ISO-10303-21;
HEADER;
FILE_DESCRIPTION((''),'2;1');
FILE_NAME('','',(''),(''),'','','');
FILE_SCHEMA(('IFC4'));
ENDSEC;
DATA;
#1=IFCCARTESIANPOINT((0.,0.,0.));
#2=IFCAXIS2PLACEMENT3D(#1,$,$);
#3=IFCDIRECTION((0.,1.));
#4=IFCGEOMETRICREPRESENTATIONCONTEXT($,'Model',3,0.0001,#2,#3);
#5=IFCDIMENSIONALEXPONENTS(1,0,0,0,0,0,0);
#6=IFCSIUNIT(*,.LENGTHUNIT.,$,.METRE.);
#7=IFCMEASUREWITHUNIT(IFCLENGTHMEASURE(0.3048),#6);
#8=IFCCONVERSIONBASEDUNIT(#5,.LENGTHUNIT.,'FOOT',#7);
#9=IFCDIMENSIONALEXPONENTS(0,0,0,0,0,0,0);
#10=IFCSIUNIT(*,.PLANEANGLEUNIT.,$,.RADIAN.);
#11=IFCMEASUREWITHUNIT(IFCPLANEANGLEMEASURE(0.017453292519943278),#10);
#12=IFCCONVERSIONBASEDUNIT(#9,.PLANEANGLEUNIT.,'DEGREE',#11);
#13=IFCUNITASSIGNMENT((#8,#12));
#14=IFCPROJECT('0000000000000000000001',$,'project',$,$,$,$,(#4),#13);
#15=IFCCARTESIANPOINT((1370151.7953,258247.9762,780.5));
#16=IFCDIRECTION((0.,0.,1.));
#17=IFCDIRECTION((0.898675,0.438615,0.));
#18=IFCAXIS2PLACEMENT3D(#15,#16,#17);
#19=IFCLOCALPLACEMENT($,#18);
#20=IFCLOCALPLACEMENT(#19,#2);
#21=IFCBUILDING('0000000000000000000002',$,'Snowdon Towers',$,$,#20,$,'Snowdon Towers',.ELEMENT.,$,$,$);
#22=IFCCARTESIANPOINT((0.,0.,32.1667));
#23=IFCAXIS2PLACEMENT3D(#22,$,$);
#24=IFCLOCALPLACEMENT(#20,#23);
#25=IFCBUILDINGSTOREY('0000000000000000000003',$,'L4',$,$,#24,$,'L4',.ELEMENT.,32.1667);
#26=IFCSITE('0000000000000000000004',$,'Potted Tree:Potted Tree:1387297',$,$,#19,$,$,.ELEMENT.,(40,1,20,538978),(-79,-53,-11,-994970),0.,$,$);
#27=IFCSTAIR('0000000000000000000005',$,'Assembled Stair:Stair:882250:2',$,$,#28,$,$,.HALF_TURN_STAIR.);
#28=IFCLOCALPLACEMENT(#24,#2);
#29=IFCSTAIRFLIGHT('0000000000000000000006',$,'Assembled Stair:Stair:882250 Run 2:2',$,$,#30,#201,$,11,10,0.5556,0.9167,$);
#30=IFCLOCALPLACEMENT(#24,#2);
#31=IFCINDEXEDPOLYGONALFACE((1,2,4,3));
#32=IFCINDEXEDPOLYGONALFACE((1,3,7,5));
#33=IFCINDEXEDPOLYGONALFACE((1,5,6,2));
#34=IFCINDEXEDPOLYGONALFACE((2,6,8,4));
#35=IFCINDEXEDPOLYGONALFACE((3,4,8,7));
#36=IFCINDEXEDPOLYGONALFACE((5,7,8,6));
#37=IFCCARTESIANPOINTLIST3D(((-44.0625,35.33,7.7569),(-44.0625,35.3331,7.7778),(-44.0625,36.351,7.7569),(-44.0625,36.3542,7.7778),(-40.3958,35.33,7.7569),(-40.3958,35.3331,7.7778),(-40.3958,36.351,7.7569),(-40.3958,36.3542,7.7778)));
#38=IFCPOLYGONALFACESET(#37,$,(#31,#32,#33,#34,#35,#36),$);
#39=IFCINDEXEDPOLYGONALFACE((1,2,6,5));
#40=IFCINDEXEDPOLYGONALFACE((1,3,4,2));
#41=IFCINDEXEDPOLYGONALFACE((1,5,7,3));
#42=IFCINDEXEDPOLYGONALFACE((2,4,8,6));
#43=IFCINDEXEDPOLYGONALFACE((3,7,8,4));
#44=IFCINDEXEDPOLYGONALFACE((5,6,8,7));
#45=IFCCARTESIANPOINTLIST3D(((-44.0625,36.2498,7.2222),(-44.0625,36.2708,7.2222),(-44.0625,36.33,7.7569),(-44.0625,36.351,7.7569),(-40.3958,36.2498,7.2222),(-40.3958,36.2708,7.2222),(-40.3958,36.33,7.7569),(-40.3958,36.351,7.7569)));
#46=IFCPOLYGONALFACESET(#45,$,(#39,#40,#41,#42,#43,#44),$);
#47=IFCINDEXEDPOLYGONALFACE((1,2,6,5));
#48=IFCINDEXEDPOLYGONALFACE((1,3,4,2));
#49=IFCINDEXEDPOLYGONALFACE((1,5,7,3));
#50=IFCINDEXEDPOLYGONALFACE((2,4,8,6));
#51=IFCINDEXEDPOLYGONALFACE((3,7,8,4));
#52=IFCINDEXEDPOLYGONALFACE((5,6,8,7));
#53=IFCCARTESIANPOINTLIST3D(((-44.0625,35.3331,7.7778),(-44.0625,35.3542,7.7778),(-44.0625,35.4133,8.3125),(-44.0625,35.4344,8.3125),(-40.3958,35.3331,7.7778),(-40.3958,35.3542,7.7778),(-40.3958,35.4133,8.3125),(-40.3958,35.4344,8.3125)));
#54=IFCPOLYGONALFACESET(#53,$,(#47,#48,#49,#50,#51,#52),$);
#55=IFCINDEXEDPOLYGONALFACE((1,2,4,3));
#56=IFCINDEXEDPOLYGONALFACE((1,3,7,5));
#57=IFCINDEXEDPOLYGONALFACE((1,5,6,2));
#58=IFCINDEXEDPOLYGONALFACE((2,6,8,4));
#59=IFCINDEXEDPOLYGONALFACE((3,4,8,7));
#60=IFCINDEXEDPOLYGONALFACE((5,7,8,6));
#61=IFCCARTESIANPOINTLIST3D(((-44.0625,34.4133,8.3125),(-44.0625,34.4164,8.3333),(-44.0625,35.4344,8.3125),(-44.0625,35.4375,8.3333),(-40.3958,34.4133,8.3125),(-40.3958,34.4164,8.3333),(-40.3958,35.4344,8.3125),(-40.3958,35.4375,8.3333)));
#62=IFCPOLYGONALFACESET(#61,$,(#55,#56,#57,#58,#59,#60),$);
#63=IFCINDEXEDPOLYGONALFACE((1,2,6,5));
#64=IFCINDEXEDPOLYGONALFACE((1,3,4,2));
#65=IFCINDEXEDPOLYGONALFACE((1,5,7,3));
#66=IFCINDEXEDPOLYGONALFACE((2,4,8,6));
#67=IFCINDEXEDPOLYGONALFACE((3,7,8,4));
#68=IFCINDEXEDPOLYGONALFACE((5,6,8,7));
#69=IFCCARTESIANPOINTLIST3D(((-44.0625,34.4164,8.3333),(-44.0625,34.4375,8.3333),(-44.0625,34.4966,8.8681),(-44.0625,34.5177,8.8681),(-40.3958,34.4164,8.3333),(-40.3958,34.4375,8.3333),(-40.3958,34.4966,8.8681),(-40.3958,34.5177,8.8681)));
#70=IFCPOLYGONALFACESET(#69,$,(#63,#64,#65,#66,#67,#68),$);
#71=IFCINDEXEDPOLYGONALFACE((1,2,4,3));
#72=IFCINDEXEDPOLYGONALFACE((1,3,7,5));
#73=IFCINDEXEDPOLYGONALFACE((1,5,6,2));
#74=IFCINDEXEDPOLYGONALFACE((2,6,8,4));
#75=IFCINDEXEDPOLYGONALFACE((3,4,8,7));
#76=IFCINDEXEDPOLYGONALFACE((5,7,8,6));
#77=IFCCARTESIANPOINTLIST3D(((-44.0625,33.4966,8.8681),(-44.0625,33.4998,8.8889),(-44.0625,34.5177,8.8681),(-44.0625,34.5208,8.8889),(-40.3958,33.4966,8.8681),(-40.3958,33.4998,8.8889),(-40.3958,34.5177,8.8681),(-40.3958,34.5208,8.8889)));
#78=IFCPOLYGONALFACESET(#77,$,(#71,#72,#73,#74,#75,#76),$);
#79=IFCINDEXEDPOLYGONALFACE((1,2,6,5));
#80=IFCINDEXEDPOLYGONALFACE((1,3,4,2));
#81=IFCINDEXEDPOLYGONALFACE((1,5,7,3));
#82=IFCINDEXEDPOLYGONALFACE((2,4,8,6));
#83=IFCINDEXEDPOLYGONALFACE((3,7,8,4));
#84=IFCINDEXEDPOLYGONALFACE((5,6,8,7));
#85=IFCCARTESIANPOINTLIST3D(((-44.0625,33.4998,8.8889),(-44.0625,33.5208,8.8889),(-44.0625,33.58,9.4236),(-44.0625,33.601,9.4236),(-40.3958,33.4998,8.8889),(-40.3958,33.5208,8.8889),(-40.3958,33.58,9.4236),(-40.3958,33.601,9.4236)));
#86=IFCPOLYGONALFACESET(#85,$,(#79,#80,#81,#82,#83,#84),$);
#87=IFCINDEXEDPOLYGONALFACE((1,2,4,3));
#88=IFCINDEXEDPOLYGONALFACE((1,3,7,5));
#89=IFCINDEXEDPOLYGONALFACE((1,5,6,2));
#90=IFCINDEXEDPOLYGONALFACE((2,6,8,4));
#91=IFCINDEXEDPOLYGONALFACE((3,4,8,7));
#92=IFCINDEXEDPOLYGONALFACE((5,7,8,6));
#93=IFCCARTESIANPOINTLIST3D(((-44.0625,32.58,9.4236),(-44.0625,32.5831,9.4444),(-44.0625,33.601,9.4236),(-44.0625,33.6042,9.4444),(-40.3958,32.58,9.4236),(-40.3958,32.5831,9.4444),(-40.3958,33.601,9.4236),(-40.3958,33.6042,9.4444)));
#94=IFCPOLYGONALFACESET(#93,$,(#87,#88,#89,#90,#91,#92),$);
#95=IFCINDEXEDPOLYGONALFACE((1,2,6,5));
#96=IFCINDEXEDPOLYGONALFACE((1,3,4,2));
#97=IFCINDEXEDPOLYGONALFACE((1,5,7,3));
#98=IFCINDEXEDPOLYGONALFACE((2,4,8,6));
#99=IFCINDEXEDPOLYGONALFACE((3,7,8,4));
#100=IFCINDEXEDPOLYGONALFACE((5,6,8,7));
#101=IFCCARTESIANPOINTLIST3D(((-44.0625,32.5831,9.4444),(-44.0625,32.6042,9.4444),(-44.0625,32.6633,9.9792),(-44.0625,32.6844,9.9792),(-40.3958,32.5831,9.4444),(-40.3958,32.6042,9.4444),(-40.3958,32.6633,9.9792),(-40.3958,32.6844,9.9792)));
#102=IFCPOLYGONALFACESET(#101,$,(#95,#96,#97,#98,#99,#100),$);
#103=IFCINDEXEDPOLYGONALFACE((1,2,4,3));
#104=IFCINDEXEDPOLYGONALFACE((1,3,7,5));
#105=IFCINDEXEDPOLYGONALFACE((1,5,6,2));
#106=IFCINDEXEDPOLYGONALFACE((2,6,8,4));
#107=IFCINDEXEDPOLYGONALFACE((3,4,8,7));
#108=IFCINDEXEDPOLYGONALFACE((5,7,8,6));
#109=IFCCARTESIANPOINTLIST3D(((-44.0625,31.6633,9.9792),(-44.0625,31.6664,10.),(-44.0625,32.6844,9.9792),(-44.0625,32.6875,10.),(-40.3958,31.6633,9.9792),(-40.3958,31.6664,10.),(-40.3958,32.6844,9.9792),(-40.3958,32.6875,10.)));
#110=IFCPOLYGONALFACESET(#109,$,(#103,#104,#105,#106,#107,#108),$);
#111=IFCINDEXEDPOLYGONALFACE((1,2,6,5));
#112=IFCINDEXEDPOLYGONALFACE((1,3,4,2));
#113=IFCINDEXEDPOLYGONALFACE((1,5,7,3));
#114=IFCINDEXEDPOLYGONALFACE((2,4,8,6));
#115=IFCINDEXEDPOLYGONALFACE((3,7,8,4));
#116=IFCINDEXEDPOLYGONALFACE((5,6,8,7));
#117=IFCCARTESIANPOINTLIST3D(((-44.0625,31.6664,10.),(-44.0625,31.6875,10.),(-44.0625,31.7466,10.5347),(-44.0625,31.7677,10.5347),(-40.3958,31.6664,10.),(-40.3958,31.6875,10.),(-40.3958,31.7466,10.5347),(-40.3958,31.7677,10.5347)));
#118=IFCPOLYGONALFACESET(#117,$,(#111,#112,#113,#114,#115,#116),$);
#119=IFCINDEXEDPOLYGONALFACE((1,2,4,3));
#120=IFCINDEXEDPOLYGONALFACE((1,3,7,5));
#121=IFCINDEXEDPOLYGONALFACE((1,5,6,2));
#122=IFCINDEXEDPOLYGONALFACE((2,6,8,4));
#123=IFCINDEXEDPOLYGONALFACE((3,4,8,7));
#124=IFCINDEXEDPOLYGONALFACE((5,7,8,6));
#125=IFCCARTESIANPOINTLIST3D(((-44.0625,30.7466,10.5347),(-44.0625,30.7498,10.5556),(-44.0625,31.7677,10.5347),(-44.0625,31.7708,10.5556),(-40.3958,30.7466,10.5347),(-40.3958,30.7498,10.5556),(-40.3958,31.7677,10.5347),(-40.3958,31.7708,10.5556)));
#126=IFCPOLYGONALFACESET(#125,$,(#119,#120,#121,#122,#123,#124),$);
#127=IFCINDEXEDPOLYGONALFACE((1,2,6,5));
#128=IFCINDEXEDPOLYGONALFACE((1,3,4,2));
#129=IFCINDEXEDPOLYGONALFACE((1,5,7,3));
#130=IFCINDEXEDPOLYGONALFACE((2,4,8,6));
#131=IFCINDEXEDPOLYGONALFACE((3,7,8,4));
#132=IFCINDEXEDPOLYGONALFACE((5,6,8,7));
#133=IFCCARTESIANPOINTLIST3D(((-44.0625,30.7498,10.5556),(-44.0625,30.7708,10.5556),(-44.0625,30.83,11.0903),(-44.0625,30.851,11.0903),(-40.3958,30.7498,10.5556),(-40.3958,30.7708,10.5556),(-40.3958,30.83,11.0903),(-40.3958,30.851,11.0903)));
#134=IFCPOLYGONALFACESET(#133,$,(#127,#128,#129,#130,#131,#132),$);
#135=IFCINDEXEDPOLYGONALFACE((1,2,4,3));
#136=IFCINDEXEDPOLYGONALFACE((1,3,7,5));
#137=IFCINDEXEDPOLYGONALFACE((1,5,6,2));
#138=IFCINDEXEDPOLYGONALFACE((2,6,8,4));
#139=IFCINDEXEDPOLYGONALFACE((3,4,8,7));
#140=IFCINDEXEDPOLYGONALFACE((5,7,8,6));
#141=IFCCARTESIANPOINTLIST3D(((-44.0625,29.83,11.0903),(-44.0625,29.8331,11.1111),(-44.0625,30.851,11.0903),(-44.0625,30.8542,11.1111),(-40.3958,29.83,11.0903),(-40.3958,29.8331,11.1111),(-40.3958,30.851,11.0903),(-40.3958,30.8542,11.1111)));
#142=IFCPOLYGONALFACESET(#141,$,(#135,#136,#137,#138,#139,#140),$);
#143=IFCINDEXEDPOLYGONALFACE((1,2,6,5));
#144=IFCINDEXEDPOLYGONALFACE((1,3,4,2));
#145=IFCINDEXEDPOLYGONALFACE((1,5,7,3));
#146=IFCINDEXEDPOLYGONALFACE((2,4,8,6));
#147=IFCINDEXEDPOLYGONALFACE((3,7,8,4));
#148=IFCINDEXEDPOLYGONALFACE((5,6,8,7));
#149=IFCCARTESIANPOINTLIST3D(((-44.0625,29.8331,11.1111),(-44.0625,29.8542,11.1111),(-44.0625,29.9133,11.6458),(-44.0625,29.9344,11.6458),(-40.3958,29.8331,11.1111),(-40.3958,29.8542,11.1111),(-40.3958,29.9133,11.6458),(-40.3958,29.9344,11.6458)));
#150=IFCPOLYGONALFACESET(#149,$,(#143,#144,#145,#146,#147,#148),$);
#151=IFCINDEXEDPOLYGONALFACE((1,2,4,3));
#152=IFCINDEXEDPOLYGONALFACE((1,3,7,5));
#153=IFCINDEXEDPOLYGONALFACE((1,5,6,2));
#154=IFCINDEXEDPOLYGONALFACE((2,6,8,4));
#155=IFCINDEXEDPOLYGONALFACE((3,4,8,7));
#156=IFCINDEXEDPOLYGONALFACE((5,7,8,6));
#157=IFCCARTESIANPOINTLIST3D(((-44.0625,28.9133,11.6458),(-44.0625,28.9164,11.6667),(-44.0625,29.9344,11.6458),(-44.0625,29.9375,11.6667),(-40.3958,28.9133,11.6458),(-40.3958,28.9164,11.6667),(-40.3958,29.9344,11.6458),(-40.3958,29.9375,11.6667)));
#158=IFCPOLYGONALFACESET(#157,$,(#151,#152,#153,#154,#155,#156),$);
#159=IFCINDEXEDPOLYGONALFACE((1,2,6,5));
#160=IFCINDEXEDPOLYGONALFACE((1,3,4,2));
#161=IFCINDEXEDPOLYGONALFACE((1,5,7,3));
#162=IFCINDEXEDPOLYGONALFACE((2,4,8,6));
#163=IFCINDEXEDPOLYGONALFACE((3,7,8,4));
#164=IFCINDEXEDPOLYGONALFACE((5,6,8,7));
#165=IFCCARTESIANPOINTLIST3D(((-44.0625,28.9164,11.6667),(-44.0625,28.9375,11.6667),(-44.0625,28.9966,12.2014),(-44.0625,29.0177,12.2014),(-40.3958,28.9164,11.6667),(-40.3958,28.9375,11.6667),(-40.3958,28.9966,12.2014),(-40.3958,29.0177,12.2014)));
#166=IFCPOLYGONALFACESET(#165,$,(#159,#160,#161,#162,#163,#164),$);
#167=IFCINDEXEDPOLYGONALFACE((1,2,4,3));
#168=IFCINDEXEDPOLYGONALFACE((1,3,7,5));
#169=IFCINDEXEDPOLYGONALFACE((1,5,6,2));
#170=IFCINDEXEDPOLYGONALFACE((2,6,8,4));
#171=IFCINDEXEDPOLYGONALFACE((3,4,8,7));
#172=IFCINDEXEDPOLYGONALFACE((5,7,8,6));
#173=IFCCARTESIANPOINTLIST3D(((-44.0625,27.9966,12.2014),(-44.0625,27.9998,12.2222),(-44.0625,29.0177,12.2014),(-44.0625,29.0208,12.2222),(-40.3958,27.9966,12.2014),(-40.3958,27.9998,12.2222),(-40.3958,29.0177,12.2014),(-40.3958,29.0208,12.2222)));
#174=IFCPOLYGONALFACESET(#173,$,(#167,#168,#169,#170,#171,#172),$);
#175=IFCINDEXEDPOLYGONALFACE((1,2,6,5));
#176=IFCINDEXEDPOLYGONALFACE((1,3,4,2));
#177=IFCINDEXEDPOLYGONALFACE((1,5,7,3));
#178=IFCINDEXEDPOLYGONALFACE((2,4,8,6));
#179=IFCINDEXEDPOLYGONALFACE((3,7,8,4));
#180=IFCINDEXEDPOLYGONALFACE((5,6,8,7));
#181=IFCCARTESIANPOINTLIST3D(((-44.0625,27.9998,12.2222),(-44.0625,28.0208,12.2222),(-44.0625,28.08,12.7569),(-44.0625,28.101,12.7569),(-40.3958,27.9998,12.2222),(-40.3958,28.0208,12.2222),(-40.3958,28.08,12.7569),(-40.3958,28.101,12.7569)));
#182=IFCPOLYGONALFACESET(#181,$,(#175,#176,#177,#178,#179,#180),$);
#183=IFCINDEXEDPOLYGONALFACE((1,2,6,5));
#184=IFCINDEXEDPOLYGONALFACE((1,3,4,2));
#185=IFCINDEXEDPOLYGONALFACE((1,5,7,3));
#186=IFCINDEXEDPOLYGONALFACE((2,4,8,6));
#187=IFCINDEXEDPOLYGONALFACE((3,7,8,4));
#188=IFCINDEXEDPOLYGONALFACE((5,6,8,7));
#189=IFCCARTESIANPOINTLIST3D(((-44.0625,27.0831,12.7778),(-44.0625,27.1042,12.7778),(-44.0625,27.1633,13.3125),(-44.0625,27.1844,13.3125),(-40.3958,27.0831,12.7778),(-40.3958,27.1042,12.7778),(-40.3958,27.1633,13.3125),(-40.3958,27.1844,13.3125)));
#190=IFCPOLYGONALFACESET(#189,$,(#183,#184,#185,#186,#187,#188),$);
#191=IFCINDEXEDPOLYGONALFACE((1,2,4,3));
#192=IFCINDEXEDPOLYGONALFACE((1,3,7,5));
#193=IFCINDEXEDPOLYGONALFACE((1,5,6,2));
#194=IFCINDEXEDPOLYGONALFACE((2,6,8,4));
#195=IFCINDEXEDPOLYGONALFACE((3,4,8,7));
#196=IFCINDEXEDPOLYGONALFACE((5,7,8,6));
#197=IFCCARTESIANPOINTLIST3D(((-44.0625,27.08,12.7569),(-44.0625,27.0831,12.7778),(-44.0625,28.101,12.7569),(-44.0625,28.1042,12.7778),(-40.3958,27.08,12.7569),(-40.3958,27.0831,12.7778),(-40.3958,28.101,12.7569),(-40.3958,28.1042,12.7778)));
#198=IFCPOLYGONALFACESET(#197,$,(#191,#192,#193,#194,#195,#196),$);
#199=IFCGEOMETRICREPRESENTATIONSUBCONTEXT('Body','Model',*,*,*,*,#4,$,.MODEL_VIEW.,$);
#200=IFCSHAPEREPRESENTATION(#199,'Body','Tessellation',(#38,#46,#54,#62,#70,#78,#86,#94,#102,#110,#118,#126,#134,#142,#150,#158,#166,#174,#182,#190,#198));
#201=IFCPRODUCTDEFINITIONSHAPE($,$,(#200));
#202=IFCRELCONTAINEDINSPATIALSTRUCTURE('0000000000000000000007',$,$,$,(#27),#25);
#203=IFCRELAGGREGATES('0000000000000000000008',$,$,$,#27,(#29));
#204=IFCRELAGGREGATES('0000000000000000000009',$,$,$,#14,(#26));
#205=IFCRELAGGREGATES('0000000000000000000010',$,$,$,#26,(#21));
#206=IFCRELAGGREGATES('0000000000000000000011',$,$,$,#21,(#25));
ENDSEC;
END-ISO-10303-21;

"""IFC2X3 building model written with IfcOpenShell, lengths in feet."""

from ifc_helpers import new_model, entity, si_unit, converted_unit, direction, frame, origin, place, context, subcontext, project, spatial, polyline, outline, extrude, element, aggregate, save


model = new_model("IFC2X3")

# Units and contexts
model_context = context("Model", 3, precision=0.0001, world=origin(), true_north=direction((0.0, 1.0)))
body_context = subcontext(model_context, "Body", "Model", "MODEL_VIEW")
ifc_project = project(units=[converted_unit("LENGTHUNIT", "FOOT", entity("IfcLengthMeasure", 0.3048), si_unit("LENGTHUNIT", "METRE"), dimensions=[1, 0, 0, 0, 0, 0, 0]), converted_unit("PLANEANGLEUNIT", "DEGREE", entity("IfcPlaneAngleMeasure", 0.017453292519943278), si_unit("PLANEANGLEUNIT", "RADIAN"), dimensions=[0, 0, 0, 0, 0, 0, 0])], contexts=[model_context])

# Site, building, storey
site_placement = place(None, frame((1370151.7953, 258247.9762, 780.5), z_axis=(0.0, 0.0, 1.0), x_axis=(0.898675, 0.438615, 0.0)))
site = spatial("IfcSite", under=ifc_project, at=site_placement, Name="Potted Tree:Potted Tree:1387297", CompositionType="ELEMENT", RefLatitude=(40, 1, 20, 538978), RefLongitude=(-79, -53, -11, -994970), RefElevation=0.0)
building_placement = place(site_placement, origin())
building = spatial("IfcBuilding", under=site, at=building_placement, Name="Snowdon Towers", LongName="Snowdon Towers", CompositionType="ELEMENT")
storey_placement = place(building_placement, frame((0.0, 0.0, 32.1667)))
storey = spatial("IfcBuildingStorey", under=building, at=storey_placement, Name="L4", LongName="L4", CompositionType="ELEMENT", Elevation=32.1667)

# Stair, stair flight
stair_1_placement = place(storey_placement, origin())
stair_1 = element("IfcStair", 1, at=stair_1_placement, inside=storey, Name="Assembled Stair:Stair:882250:2", ShapeType="HALF_TURN_STAIR")
stair_flight_placement = place(stair_1_placement, origin())
stair_flight = element("IfcStairFlight", 2, at=stair_flight_placement, Name="Assembled Stair:Stair:882250 Run 2:2", NumberOfRiser=11, NumberOfTreads=10, RiserHeight=0.5556, TreadLength=0.9167, context=body_context, shape_type="SweptSolid", body=[
    extrude(outline(polyline([(0.0652, -0.5049), (0.0863, -0.5049), (-0.0652, 0.5049), (-0.0863, 0.5049), (0.0652, -0.5049)])), frame((-44.0625, 35.8421, 7.7674), z_axis=(1.0, 0.0, 0.0), x_axis=(0.0, -0.14834, -0.988936)), (0.0, 0.0, 1.0), 3.6667),
    extrude(outline(polyline([(-0.0506, -0.2674), (-0.0296, -0.2674), (0.0506, 0.2674), (0.0296, 0.2674), (-0.0506, -0.2674)])), frame((-44.0625, 36.3004, 7.4896), z_axis=(1.0, 0.0, 0.0), x_axis=(0.0, -1.0, 0.0)), (0.0, 0.0, 1.0), 3.6667),
    extrude(outline(polyline([(-0.0506, -0.2674), (-0.0296, -0.2674), (0.0506, 0.2674), (0.0296, 0.2674), (-0.0506, -0.2674)])), frame((-44.0625, 35.3837, 8.0451), z_axis=(1.0, 0.0, 0.0), x_axis=(0.0, -1.0, 0.0)), (0.0, 0.0, 1.0), 3.6667),
    extrude(outline(polyline([(0.0652, -0.5049), (0.0863, -0.5049), (-0.0652, 0.5049), (-0.0863, 0.5049), (0.0652, -0.5049)])), frame((-44.0625, 34.9254, 8.3229), z_axis=(1.0, 0.0, 0.0), x_axis=(0.0, -0.14834, -0.988936)), (0.0, 0.0, 1.0), 3.6667),
    extrude(outline(polyline([(-0.0506, -0.2674), (-0.0296, -0.2674), (0.0506, 0.2674), (0.0296, 0.2674), (-0.0506, -0.2674)])), frame((-44.0625, 34.4671, 8.6007), z_axis=(1.0, 0.0, 0.0), x_axis=(0.0, -1.0, 0.0)), (0.0, 0.0, 1.0), 3.6667),
    extrude(outline(polyline([(0.0652, -0.5049), (0.0863, -0.5049), (-0.0652, 0.5049), (-0.0863, 0.5049), (0.0652, -0.5049)])), frame((-44.0625, 34.0087, 8.8785), z_axis=(1.0, 0.0, 0.0), x_axis=(0.0, -0.14834, -0.988936)), (0.0, 0.0, 1.0), 3.6667),
    extrude(outline(polyline([(-0.0506, -0.2674), (-0.0296, -0.2674), (0.0506, 0.2674), (0.0296, 0.2674), (-0.0506, -0.2674)])), frame((-44.0625, 33.5504, 9.1562), z_axis=(1.0, 0.0, 0.0), x_axis=(0.0, -1.0, 0.0)), (0.0, 0.0, 1.0), 3.6667),
    extrude(outline(polyline([(0.0652, -0.5049), (0.0863, -0.5049), (-0.0652, 0.5049), (-0.0863, 0.5049), (0.0652, -0.5049)])), frame((-44.0625, 33.0921, 9.434), z_axis=(1.0, 0.0, 0.0), x_axis=(0.0, -0.14834, -0.988936)), (0.0, 0.0, 1.0), 3.6667),
    extrude(outline(polyline([(-0.0506, -0.2674), (-0.0296, -0.2674), (0.0506, 0.2674), (0.0296, 0.2674), (-0.0506, -0.2674)])), frame((-44.0625, 32.6337, 9.7118), z_axis=(1.0, 0.0, 0.0), x_axis=(0.0, -1.0, 0.0)), (0.0, 0.0, 1.0), 3.6667),
    extrude(outline(polyline([(0.0652, -0.5049), (0.0863, -0.5049), (-0.0652, 0.5049), (-0.0863, 0.5049), (0.0652, -0.5049)])), frame((-44.0625, 32.1754, 9.9896), z_axis=(1.0, 0.0, 0.0), x_axis=(0.0, -0.14834, -0.988936)), (0.0, 0.0, 1.0), 3.6667),
    extrude(outline(polyline([(-0.0506, -0.2674), (-0.0296, -0.2674), (0.0506, 0.2674), (0.0296, 0.2674), (-0.0506, -0.2674)])), frame((-44.0625, 31.7171, 10.2674), z_axis=(1.0, 0.0, 0.0), x_axis=(0.0, -1.0, 0.0)), (0.0, 0.0, 1.0), 3.6667),
    extrude(outline(polyline([(0.0652, -0.5049), (0.0863, -0.5049), (-0.0652, 0.5049), (-0.0863, 0.5049), (0.0652, -0.5049)])), frame((-44.0625, 31.2587, 10.5451), z_axis=(1.0, 0.0, 0.0), x_axis=(0.0, -0.14834, -0.988936)), (0.0, 0.0, 1.0), 3.6667),
    extrude(outline(polyline([(-0.0506, -0.2674), (-0.0296, -0.2674), (0.0506, 0.2674), (0.0296, 0.2674), (-0.0506, -0.2674)])), frame((-44.0625, 30.8004, 10.8229), z_axis=(1.0, 0.0, 0.0), x_axis=(0.0, -1.0, 0.0)), (0.0, 0.0, 1.0), 3.6667),
    extrude(outline(polyline([(0.0652, -0.5049), (0.0863, -0.5049), (-0.0652, 0.5049), (-0.0863, 0.5049), (0.0652, -0.5049)])), frame((-44.0625, 30.3421, 11.1007), z_axis=(1.0, 0.0, 0.0), x_axis=(0.0, -0.14834, -0.988936)), (0.0, 0.0, 1.0), 3.6667),
    extrude(outline(polyline([(-0.0506, -0.2674), (-0.0296, -0.2674), (0.0506, 0.2674), (0.0296, 0.2674), (-0.0506, -0.2674)])), frame((-44.0625, 29.8837, 11.3785), z_axis=(1.0, 0.0, 0.0), x_axis=(0.0, -1.0, 0.0)), (0.0, 0.0, 1.0), 3.6667),
    extrude(outline(polyline([(0.0652, -0.5049), (0.0863, -0.5049), (-0.0652, 0.5049), (-0.0863, 0.5049), (0.0652, -0.5049)])), frame((-44.0625, 29.4254, 11.6563), z_axis=(1.0, 0.0, 0.0), x_axis=(0.0, -0.14834, -0.988936)), (0.0, 0.0, 1.0), 3.6667),
    extrude(outline(polyline([(-0.0506, -0.2674), (-0.0296, -0.2674), (0.0506, 0.2674), (0.0296, 0.2674), (-0.0506, -0.2674)])), frame((-44.0625, 28.9671, 11.934), z_axis=(1.0, 0.0, 0.0), x_axis=(0.0, -1.0, 0.0)), (0.0, 0.0, 1.0), 3.6667),
    extrude(outline(polyline([(0.0652, -0.5049), (0.0863, -0.5049), (-0.0652, 0.5049), (-0.0863, 0.5049), (0.0652, -0.5049)])), frame((-44.0625, 28.5087, 12.2118), z_axis=(1.0, 0.0, 0.0), x_axis=(0.0, -0.14834, -0.988936)), (0.0, 0.0, 1.0), 3.6667),
    extrude(outline(polyline([(-0.0506, -0.2674), (-0.0296, -0.2674), (0.0506, 0.2674), (0.0296, 0.2674), (-0.0506, -0.2674)])), frame((-44.0625, 28.0504, 12.4896), z_axis=(1.0, 0.0, 0.0), x_axis=(0.0, -1.0, 0.0)), (0.0, 0.0, 1.0), 3.6667),
    extrude(outline(polyline([(-0.0506, -0.2674), (-0.0296, -0.2674), (0.0506, 0.2674), (0.0296, 0.2674), (-0.0506, -0.2674)])), frame((-44.0625, 27.1337, 13.0451), z_axis=(1.0, 0.0, 0.0), x_axis=(0.0, -1.0, 0.0)), (0.0, 0.0, 1.0), 3.6667),
    extrude(outline(polyline([(0.0652, -0.5049), (0.0863, -0.5049), (-0.0652, 0.5049), (-0.0863, 0.5049), (0.0652, -0.5049)])), frame((-44.0625, 27.5921, 12.7674), z_axis=(1.0, 0.0, 0.0), x_axis=(0.0, -0.14834, -0.988936)), (0.0, 0.0, 1.0), 3.6667),
])
aggregate(stair_1, [stair_flight])

save(model, "model.ifc")
